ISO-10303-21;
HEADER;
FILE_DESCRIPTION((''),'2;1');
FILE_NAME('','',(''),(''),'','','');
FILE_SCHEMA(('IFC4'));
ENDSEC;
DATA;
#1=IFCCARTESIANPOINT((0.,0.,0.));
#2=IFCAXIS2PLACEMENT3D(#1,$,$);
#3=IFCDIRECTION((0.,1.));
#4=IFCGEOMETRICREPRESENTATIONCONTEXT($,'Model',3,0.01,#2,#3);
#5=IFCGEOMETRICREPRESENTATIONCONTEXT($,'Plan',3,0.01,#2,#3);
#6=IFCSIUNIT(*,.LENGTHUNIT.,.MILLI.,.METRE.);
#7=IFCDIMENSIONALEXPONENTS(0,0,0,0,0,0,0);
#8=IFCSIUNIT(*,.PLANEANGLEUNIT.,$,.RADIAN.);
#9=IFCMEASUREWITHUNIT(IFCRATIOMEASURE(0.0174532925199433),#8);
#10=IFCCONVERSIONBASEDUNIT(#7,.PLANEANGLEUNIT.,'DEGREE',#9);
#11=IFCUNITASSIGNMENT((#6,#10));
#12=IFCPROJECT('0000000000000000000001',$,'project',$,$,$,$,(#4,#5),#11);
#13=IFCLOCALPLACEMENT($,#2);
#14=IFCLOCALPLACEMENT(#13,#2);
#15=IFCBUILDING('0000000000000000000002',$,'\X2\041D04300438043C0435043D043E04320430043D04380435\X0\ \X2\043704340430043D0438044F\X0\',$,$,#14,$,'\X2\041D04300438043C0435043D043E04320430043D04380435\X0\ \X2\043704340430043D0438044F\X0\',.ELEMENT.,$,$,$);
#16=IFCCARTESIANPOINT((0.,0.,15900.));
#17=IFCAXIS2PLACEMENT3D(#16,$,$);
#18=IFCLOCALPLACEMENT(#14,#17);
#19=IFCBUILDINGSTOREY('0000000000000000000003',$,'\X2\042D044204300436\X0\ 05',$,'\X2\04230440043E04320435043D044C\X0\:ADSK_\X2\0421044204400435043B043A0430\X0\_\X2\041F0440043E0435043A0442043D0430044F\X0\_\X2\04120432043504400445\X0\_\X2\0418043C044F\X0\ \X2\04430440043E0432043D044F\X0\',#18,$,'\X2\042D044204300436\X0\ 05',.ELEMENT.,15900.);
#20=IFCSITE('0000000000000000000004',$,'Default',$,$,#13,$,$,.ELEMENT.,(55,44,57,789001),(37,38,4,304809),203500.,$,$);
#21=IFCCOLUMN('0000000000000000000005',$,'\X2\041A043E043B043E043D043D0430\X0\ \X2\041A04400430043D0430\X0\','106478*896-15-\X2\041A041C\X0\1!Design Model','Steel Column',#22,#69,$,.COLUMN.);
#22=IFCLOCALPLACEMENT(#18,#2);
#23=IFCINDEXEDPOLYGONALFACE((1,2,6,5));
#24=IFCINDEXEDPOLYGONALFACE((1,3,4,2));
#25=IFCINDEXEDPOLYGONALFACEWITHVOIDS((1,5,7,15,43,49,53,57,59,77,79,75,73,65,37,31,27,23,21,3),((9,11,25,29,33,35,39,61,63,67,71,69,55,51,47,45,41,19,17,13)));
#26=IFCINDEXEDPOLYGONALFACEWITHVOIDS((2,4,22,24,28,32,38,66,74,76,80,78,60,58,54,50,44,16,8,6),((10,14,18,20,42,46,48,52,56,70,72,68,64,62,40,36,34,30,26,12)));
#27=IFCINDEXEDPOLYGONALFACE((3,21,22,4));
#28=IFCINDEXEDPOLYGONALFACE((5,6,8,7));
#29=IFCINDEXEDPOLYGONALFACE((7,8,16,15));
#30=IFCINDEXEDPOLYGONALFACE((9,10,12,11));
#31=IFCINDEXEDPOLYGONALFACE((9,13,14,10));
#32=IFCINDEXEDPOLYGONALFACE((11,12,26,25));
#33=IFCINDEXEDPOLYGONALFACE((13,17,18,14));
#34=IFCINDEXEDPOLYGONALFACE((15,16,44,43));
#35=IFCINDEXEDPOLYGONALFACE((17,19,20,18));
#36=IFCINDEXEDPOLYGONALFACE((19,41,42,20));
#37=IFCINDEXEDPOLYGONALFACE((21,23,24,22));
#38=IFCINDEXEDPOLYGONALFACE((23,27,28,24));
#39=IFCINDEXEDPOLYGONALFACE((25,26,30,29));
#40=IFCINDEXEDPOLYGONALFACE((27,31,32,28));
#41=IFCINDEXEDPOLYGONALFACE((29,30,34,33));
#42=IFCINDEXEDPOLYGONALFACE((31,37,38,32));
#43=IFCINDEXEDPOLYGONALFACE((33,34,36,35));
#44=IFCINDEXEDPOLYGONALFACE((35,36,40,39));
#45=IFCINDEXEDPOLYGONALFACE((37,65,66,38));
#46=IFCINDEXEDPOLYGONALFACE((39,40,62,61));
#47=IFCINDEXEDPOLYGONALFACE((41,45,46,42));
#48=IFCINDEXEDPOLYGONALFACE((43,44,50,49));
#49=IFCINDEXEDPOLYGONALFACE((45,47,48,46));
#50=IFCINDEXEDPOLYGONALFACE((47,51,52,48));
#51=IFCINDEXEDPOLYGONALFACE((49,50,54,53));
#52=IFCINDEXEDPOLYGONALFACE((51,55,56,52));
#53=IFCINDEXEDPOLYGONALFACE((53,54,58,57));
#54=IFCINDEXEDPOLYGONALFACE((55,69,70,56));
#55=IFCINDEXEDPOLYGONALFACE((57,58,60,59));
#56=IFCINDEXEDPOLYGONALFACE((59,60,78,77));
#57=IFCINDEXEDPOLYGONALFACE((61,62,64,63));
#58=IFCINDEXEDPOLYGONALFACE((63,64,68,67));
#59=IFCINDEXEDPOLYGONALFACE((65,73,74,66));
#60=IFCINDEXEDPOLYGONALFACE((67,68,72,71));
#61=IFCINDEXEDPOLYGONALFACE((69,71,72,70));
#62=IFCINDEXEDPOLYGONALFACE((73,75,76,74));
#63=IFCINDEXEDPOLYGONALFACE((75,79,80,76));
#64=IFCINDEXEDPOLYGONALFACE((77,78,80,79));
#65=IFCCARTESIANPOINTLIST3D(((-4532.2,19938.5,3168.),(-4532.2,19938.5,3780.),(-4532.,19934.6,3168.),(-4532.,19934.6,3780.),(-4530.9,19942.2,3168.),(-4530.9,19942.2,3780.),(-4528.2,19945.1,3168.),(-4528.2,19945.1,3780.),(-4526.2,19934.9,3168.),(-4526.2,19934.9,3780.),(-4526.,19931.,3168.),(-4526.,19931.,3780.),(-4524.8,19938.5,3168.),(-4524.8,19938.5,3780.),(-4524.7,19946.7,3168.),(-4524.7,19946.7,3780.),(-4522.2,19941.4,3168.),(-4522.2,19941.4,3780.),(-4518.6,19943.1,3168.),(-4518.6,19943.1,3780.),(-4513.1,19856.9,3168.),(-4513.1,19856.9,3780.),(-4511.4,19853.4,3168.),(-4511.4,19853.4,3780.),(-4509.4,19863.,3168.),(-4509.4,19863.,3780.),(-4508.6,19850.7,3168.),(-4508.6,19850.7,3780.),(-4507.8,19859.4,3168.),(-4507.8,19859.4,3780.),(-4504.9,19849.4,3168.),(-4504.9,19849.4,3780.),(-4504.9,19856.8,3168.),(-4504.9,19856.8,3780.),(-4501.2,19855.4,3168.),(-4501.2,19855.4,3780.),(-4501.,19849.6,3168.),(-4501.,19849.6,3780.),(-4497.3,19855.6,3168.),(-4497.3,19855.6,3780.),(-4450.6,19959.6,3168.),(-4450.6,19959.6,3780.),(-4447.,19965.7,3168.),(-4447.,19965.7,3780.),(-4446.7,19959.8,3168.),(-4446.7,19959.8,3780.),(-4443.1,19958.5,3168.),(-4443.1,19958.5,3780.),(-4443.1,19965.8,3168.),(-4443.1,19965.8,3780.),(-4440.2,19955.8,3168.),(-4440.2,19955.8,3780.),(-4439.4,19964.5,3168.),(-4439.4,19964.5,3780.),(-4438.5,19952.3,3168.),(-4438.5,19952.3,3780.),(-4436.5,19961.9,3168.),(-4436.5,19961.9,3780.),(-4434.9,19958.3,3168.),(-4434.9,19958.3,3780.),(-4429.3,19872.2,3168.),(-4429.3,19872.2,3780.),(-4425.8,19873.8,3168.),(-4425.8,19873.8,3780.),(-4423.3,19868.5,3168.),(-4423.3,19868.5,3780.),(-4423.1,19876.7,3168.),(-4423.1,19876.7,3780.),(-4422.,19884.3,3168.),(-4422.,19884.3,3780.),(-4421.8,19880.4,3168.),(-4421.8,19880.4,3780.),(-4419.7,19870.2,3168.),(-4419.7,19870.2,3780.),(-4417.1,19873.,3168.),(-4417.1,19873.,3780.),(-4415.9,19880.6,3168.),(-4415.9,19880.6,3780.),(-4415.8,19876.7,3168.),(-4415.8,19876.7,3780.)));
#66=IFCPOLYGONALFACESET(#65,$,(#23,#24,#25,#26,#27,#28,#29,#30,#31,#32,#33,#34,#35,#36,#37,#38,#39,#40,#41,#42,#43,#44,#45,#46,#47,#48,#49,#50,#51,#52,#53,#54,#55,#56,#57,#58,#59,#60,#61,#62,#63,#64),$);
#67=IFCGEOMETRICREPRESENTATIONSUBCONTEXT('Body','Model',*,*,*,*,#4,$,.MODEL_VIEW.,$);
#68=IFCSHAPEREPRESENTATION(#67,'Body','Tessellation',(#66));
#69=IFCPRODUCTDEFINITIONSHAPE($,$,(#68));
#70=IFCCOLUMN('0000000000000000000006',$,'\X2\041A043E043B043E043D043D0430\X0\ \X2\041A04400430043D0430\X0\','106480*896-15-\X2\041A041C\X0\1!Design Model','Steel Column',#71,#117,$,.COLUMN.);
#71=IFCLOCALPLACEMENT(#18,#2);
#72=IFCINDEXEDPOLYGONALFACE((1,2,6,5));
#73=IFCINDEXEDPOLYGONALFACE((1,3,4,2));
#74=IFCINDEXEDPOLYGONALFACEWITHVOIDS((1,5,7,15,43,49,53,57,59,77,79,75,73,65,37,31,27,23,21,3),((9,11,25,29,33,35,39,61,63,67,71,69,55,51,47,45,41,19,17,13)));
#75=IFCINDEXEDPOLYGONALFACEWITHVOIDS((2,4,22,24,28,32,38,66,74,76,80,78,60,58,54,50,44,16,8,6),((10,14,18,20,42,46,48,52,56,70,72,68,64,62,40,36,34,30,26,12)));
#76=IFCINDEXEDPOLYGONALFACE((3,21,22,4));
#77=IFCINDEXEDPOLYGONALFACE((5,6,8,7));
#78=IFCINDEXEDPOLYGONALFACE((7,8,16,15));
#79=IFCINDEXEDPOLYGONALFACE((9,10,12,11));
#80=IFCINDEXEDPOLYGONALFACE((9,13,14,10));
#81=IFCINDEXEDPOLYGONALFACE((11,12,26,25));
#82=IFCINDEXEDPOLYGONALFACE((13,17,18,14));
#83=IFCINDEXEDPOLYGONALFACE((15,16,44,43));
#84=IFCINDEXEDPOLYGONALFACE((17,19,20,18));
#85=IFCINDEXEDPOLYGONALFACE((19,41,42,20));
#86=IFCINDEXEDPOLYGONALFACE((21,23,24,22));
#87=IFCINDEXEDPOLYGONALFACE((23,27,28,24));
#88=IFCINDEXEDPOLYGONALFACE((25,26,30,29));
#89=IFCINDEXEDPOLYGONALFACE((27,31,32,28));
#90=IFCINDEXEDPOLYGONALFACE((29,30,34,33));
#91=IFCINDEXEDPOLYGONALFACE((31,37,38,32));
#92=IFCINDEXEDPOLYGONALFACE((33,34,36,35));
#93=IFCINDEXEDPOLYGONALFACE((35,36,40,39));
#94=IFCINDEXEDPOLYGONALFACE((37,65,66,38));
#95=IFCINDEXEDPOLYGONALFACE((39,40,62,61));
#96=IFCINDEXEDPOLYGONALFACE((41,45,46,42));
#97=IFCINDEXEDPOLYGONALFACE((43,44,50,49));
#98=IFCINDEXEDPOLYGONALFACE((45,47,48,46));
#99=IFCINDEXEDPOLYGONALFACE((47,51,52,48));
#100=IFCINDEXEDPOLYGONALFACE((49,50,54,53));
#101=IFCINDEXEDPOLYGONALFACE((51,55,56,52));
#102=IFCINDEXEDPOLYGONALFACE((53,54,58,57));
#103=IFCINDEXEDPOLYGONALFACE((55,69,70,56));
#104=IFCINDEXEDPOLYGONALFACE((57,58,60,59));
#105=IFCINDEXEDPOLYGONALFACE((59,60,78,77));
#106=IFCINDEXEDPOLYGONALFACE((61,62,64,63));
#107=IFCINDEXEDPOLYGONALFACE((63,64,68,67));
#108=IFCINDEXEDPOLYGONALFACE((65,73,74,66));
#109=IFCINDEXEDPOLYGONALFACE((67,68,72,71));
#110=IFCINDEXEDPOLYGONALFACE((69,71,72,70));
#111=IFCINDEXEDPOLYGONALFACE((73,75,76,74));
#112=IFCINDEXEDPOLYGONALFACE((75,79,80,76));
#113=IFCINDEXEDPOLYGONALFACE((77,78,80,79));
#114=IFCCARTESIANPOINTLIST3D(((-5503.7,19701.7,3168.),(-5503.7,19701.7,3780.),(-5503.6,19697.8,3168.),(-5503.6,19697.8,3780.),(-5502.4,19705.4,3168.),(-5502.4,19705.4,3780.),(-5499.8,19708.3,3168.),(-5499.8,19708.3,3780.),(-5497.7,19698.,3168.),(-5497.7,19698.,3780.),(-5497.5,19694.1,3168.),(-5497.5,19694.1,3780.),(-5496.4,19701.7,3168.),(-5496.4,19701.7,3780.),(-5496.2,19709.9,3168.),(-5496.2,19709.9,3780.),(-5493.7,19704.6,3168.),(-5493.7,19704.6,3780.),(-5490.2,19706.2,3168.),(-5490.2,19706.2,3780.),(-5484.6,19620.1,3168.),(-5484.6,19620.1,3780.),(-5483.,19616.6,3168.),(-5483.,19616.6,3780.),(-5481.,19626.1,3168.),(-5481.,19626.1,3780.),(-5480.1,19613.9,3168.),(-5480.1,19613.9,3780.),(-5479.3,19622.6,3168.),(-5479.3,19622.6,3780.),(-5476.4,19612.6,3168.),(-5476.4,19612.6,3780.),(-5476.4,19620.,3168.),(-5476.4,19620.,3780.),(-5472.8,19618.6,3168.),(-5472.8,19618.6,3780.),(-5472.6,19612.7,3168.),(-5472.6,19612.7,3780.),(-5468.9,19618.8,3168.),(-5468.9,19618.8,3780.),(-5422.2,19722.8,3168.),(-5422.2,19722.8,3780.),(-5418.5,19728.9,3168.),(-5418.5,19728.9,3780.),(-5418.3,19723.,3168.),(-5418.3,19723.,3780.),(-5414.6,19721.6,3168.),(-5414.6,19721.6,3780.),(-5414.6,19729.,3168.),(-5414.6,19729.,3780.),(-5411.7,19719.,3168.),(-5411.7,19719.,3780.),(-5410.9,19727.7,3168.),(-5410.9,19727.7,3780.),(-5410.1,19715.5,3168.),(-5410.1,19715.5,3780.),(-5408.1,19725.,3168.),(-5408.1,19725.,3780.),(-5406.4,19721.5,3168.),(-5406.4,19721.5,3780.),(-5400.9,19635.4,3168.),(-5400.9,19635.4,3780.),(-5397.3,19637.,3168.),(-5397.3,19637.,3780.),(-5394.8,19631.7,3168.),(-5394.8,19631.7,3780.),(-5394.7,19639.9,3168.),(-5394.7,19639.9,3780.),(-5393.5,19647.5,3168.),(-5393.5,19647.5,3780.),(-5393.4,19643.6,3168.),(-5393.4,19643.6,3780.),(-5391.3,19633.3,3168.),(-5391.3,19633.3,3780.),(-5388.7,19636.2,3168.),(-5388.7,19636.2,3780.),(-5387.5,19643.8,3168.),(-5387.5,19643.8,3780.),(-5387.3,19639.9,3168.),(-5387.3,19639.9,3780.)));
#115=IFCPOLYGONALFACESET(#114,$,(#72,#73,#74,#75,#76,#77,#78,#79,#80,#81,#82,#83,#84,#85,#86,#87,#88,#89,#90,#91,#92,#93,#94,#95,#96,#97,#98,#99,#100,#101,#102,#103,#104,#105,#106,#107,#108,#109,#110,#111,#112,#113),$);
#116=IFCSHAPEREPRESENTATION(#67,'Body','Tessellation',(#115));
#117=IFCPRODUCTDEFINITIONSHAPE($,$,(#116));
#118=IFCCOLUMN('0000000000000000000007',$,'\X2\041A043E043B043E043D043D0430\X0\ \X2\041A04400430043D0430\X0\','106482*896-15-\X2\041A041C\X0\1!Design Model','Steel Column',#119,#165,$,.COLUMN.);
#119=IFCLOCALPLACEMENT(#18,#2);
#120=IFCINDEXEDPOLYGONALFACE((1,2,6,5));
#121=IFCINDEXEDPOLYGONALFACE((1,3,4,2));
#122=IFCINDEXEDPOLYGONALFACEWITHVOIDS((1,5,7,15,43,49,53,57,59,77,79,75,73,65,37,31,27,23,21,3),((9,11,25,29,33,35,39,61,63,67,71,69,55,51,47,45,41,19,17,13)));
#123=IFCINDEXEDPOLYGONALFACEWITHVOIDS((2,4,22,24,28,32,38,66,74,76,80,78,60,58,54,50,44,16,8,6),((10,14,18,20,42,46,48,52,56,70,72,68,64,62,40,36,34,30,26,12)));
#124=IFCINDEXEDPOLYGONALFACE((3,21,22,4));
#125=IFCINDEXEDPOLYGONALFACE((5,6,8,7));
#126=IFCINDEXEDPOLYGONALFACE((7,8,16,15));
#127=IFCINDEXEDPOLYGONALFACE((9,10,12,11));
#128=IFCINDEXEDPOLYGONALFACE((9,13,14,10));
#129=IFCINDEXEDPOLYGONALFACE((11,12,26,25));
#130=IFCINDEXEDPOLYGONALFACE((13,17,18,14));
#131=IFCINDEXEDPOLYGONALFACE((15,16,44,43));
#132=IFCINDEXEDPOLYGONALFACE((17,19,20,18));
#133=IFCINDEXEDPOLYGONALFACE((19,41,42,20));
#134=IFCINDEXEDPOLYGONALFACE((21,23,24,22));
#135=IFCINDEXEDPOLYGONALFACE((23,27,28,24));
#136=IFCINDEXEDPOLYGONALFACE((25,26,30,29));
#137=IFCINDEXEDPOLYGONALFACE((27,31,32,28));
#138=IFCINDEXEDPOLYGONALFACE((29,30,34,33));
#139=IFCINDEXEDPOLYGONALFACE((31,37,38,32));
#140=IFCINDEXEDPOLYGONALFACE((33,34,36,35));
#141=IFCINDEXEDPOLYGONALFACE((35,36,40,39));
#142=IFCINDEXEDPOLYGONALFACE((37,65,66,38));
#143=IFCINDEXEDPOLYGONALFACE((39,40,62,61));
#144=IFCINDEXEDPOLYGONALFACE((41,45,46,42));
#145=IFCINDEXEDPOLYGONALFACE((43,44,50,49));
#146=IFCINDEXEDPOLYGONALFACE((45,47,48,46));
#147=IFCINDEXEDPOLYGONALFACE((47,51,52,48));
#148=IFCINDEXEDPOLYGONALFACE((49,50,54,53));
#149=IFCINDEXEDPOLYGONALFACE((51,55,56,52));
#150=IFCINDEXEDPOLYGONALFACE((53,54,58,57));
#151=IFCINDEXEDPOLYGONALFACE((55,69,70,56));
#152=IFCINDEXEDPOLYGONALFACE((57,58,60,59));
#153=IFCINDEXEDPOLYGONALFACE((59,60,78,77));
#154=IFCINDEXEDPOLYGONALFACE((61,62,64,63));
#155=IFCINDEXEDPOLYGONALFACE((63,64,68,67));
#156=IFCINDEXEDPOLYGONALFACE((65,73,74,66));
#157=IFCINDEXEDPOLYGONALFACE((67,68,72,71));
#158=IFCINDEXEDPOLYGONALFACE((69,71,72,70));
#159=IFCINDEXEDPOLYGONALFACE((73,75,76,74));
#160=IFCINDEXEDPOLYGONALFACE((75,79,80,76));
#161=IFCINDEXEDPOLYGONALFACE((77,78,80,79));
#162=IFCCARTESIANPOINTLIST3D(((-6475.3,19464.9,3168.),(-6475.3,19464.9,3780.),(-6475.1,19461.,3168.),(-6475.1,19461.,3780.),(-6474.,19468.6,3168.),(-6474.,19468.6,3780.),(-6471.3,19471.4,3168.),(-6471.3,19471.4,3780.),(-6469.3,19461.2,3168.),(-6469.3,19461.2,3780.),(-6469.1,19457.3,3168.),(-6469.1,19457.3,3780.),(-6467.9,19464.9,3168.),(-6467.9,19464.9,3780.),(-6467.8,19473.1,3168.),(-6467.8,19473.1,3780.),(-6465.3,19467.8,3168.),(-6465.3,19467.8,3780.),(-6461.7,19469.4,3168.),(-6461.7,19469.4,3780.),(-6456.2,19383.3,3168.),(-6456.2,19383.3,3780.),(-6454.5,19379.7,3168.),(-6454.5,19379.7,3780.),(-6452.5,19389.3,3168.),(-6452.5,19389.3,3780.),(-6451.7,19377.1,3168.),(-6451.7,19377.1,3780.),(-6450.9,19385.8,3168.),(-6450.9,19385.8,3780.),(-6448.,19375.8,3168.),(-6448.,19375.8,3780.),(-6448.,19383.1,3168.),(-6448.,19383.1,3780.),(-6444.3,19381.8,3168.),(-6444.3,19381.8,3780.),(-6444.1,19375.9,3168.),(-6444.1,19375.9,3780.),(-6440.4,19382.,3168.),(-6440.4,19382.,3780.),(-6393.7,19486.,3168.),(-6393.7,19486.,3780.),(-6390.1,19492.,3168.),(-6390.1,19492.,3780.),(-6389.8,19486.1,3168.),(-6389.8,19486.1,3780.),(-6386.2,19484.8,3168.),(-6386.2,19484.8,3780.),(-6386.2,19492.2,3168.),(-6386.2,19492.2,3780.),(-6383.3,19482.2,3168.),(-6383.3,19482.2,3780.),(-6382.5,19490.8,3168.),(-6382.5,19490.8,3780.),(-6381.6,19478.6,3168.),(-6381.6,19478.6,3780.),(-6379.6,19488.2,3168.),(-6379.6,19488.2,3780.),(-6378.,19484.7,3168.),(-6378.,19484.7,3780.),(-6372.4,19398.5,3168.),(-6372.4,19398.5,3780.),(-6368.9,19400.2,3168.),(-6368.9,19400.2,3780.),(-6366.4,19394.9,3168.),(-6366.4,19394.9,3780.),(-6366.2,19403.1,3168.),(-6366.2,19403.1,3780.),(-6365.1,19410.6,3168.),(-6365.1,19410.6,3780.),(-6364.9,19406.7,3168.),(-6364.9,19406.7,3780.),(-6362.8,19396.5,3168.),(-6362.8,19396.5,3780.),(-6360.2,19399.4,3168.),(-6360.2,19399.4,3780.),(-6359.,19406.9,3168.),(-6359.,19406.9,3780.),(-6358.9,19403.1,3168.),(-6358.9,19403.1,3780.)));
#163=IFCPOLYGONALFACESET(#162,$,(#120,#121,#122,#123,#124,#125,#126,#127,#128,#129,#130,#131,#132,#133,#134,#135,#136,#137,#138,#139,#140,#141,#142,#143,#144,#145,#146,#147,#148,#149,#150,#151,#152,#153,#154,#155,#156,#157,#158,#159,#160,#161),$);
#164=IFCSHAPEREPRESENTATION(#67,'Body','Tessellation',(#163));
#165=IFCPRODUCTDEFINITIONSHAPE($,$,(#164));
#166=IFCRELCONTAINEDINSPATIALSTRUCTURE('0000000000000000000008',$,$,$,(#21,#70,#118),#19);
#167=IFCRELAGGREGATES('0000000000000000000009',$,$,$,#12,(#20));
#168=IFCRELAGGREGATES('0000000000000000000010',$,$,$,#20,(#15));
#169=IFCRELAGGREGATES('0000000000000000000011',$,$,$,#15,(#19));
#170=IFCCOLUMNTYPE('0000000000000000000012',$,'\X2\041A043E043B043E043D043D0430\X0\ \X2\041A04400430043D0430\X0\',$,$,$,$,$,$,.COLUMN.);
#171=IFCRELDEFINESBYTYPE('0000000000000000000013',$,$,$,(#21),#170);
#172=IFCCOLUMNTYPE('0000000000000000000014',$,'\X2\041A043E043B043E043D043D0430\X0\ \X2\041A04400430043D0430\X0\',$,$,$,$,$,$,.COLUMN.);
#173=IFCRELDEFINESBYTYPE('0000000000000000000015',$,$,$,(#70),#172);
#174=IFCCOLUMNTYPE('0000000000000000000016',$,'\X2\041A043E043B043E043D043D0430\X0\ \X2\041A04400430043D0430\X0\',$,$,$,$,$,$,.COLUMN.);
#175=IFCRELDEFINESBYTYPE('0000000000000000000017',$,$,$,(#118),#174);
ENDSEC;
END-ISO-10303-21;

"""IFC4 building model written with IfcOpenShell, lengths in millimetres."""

from ifc_helpers import new_model, entity, si_unit, converted_unit, direction, frame, origin, place, context, subcontext, project, spatial, indexed_curve, outline, extrude, type_object, element, save


model = new_model("IFC4")

# Units and contexts
model_context = context("Model", 3, precision=0.01, world=origin(), true_north=direction((0.0, 1.0)))
plan_context = context("Plan", 3, precision=0.01, world=origin(), true_north=direction((0.0, 1.0)))
body_context = subcontext(model_context, "Body", "Model", "MODEL_VIEW")
ifc_project = project(units=[si_unit("LENGTHUNIT", "METRE", prefix="MILLI"), converted_unit("PLANEANGLEUNIT", "DEGREE", entity("IfcRatioMeasure", 0.0174532925199433), si_unit("PLANEANGLEUNIT", "RADIAN"), dimensions=[0, 0, 0, 0, 0, 0, 0])], contexts=[model_context, plan_context])

# Site, building, storey
site_placement = place(None, origin())
site = spatial("IfcSite", under=ifc_project, at=site_placement, Name="Default", CompositionType="ELEMENT", RefLatitude=(55, 44, 57, 789001), RefLongitude=(37, 38, 4, 304809), RefElevation=203500.0)
building_placement = place(site_placement, origin())
building = spatial("IfcBuilding", under=site, at=building_placement, Name="Наименование здания", LongName="Наименование здания", CompositionType="ELEMENT")
storey_placement = place(building_placement, frame((0.0, 0.0, 15900.0)))
storey = spatial("IfcBuildingStorey", under=building, at=storey_placement, Name="Этаж 05", ObjectType="Уровень:ADSK_Стрелка_Проектная_Вверх_Имя уровня", LongName="Этаж 05", CompositionType="ELEMENT", Elevation=15900.0)

# Columns
placement = place(storey_placement, origin())
column_type_1 = type_object("IfcColumnType", Name="Колонна Крана", PredefinedType="COLUMN")
element("IfcColumn", 1, at=placement, inside=storey, type_object=column_type_1, Name="Колонна Крана", Description="106478*896-15-КМ1!Design Model", ObjectType="Steel Column", PredefinedType="COLUMN", context=body_context, shape_type="SweptSolid", body=[
    extrude(outline(indexed_curve([(29.5, -56.8), (33.4, -56.8), (37.0, -55.3), (39.7, -52.6), (41.2, -49.0), (56.8, 29.5), (56.8, 33.4), (55.3, 37.0), (52.6, 39.7), (49.0, 41.2), (-29.5, 56.8), (-33.4, 56.8), (-37.0, 55.3), (-39.7, 52.6), (-41.2, 49.0), (-56.8, -29.5), (-56.8, -33.4), (-55.3, -37.0), (-52.6, -39.7), (-49.0, -41.2), (29.5, -56.8)], self_intersect=False), holes=[indexed_curve([(-43.1, -37.3), (-46.7, -35.8), (-49.5, -33.1), (-51.0, -29.5), (-51.0, -25.5), (-37.3, 43.1), (-35.8, 46.7), (-33.1, 49.5), (-29.5, 51.0), (-25.5, 51.0), (43.1, 37.3), (46.7, 35.8), (49.5, 33.1), (51.0, 29.5), (51.0, 25.5), (37.3, -43.1), (35.8, -46.7), (33.1, -49.5), (29.5, -51.0), (25.5, -51.0), (-43.1, -37.3)], self_intersect=False)]), frame((-4474.0, 19907.6, 3168.0), z_axis=(0.0, 0.0, 1.0), x_axis=(0.906681, 0.421816, 0.0)), (0.0, 0.0, 1.0), 612.0),
])
column_type_2 = type_object("IfcColumnType", Name="Колонна Крана", PredefinedType="COLUMN")
element("IfcColumn", 2, at=placement, inside=storey, type_object=column_type_2, Name="Колонна Крана", Description="106480*896-15-КМ1!Design Model", ObjectType="Steel Column", PredefinedType="COLUMN", context=body_context, shape_type="SweptSolid", body=[
    extrude(outline(indexed_curve([(29.5, -56.8), (33.4, -56.8), (37.0, -55.3), (39.7, -52.6), (41.2, -49.0), (56.8, 29.5), (56.8, 33.4), (55.3, 37.0), (52.6, 39.7), (49.0, 41.2), (-29.5, 56.8), (-33.4, 56.8), (-37.0, 55.3), (-39.7, 52.6), (-41.2, 49.0), (-56.8, -29.5), (-56.8, -33.4), (-55.3, -37.0), (-52.6, -39.7), (-49.0, -41.2), (29.5, -56.8)], self_intersect=False), holes=[indexed_curve([(-43.1, -37.3), (-46.7, -35.8), (-49.5, -33.1), (-51.0, -29.5), (-51.0, -25.5), (-37.3, 43.1), (-35.8, 46.7), (-33.1, 49.5), (-29.5, 51.0), (-25.5, 51.0), (43.1, 37.3), (46.7, 35.8), (49.5, 33.1), (51.0, 29.5), (51.0, 25.5), (37.3, -43.1), (35.8, -46.7), (33.1, -49.5), (29.5, -51.0), (25.5, -51.0), (-43.1, -37.3)], self_intersect=False)]), frame((-5445.5, 19670.8, 3168.0), z_axis=(0.0, 0.0, 1.0), x_axis=(0.906681, 0.421816, 0.0)), (0.0, 0.0, 1.0), 612.0),
])
column_type_3 = type_object("IfcColumnType", Name="Колонна Крана", PredefinedType="COLUMN")
element("IfcColumn", 3, at=placement, inside=storey, type_object=column_type_3, Name="Колонна Крана", Description="106482*896-15-КМ1!Design Model", ObjectType="Steel Column", PredefinedType="COLUMN", context=body_context, shape_type="SweptSolid", body=[
    extrude(outline(indexed_curve([(29.5, -56.8), (33.4, -56.8), (37.0, -55.3), (39.7, -52.6), (41.2, -49.0), (56.8, 29.5), (56.8, 33.4), (55.3, 37.0), (52.6, 39.7), (49.0, 41.2), (-29.5, 56.8), (-33.4, 56.8), (-37.0, 55.3), (-39.7, 52.6), (-41.2, 49.0), (-56.8, -29.5), (-56.8, -33.4), (-55.3, -37.0), (-52.6, -39.7), (-49.0, -41.2), (29.5, -56.8)], self_intersect=False), holes=[indexed_curve([(-43.1, -37.3), (-46.7, -35.8), (-49.5, -33.1), (-51.0, -29.5), (-51.0, -25.5), (-37.3, 43.1), (-35.8, 46.7), (-33.1, 49.5), (-29.5, 51.0), (-25.5, 51.0), (43.1, 37.3), (46.7, 35.8), (49.5, 33.1), (51.0, 29.5), (51.0, 25.5), (37.3, -43.1), (35.8, -46.7), (33.1, -49.5), (29.5, -51.0), (25.5, -51.0), (-43.1, -37.3)], self_intersect=False)]), frame((-6417.1, 19434.0, 3168.0), z_axis=(0.0, 0.0, 1.0), x_axis=(0.906681, 0.421816, 0.0)), (0.0, 0.0, 1.0), 612.0),
])

save(model, "model.ifc")
